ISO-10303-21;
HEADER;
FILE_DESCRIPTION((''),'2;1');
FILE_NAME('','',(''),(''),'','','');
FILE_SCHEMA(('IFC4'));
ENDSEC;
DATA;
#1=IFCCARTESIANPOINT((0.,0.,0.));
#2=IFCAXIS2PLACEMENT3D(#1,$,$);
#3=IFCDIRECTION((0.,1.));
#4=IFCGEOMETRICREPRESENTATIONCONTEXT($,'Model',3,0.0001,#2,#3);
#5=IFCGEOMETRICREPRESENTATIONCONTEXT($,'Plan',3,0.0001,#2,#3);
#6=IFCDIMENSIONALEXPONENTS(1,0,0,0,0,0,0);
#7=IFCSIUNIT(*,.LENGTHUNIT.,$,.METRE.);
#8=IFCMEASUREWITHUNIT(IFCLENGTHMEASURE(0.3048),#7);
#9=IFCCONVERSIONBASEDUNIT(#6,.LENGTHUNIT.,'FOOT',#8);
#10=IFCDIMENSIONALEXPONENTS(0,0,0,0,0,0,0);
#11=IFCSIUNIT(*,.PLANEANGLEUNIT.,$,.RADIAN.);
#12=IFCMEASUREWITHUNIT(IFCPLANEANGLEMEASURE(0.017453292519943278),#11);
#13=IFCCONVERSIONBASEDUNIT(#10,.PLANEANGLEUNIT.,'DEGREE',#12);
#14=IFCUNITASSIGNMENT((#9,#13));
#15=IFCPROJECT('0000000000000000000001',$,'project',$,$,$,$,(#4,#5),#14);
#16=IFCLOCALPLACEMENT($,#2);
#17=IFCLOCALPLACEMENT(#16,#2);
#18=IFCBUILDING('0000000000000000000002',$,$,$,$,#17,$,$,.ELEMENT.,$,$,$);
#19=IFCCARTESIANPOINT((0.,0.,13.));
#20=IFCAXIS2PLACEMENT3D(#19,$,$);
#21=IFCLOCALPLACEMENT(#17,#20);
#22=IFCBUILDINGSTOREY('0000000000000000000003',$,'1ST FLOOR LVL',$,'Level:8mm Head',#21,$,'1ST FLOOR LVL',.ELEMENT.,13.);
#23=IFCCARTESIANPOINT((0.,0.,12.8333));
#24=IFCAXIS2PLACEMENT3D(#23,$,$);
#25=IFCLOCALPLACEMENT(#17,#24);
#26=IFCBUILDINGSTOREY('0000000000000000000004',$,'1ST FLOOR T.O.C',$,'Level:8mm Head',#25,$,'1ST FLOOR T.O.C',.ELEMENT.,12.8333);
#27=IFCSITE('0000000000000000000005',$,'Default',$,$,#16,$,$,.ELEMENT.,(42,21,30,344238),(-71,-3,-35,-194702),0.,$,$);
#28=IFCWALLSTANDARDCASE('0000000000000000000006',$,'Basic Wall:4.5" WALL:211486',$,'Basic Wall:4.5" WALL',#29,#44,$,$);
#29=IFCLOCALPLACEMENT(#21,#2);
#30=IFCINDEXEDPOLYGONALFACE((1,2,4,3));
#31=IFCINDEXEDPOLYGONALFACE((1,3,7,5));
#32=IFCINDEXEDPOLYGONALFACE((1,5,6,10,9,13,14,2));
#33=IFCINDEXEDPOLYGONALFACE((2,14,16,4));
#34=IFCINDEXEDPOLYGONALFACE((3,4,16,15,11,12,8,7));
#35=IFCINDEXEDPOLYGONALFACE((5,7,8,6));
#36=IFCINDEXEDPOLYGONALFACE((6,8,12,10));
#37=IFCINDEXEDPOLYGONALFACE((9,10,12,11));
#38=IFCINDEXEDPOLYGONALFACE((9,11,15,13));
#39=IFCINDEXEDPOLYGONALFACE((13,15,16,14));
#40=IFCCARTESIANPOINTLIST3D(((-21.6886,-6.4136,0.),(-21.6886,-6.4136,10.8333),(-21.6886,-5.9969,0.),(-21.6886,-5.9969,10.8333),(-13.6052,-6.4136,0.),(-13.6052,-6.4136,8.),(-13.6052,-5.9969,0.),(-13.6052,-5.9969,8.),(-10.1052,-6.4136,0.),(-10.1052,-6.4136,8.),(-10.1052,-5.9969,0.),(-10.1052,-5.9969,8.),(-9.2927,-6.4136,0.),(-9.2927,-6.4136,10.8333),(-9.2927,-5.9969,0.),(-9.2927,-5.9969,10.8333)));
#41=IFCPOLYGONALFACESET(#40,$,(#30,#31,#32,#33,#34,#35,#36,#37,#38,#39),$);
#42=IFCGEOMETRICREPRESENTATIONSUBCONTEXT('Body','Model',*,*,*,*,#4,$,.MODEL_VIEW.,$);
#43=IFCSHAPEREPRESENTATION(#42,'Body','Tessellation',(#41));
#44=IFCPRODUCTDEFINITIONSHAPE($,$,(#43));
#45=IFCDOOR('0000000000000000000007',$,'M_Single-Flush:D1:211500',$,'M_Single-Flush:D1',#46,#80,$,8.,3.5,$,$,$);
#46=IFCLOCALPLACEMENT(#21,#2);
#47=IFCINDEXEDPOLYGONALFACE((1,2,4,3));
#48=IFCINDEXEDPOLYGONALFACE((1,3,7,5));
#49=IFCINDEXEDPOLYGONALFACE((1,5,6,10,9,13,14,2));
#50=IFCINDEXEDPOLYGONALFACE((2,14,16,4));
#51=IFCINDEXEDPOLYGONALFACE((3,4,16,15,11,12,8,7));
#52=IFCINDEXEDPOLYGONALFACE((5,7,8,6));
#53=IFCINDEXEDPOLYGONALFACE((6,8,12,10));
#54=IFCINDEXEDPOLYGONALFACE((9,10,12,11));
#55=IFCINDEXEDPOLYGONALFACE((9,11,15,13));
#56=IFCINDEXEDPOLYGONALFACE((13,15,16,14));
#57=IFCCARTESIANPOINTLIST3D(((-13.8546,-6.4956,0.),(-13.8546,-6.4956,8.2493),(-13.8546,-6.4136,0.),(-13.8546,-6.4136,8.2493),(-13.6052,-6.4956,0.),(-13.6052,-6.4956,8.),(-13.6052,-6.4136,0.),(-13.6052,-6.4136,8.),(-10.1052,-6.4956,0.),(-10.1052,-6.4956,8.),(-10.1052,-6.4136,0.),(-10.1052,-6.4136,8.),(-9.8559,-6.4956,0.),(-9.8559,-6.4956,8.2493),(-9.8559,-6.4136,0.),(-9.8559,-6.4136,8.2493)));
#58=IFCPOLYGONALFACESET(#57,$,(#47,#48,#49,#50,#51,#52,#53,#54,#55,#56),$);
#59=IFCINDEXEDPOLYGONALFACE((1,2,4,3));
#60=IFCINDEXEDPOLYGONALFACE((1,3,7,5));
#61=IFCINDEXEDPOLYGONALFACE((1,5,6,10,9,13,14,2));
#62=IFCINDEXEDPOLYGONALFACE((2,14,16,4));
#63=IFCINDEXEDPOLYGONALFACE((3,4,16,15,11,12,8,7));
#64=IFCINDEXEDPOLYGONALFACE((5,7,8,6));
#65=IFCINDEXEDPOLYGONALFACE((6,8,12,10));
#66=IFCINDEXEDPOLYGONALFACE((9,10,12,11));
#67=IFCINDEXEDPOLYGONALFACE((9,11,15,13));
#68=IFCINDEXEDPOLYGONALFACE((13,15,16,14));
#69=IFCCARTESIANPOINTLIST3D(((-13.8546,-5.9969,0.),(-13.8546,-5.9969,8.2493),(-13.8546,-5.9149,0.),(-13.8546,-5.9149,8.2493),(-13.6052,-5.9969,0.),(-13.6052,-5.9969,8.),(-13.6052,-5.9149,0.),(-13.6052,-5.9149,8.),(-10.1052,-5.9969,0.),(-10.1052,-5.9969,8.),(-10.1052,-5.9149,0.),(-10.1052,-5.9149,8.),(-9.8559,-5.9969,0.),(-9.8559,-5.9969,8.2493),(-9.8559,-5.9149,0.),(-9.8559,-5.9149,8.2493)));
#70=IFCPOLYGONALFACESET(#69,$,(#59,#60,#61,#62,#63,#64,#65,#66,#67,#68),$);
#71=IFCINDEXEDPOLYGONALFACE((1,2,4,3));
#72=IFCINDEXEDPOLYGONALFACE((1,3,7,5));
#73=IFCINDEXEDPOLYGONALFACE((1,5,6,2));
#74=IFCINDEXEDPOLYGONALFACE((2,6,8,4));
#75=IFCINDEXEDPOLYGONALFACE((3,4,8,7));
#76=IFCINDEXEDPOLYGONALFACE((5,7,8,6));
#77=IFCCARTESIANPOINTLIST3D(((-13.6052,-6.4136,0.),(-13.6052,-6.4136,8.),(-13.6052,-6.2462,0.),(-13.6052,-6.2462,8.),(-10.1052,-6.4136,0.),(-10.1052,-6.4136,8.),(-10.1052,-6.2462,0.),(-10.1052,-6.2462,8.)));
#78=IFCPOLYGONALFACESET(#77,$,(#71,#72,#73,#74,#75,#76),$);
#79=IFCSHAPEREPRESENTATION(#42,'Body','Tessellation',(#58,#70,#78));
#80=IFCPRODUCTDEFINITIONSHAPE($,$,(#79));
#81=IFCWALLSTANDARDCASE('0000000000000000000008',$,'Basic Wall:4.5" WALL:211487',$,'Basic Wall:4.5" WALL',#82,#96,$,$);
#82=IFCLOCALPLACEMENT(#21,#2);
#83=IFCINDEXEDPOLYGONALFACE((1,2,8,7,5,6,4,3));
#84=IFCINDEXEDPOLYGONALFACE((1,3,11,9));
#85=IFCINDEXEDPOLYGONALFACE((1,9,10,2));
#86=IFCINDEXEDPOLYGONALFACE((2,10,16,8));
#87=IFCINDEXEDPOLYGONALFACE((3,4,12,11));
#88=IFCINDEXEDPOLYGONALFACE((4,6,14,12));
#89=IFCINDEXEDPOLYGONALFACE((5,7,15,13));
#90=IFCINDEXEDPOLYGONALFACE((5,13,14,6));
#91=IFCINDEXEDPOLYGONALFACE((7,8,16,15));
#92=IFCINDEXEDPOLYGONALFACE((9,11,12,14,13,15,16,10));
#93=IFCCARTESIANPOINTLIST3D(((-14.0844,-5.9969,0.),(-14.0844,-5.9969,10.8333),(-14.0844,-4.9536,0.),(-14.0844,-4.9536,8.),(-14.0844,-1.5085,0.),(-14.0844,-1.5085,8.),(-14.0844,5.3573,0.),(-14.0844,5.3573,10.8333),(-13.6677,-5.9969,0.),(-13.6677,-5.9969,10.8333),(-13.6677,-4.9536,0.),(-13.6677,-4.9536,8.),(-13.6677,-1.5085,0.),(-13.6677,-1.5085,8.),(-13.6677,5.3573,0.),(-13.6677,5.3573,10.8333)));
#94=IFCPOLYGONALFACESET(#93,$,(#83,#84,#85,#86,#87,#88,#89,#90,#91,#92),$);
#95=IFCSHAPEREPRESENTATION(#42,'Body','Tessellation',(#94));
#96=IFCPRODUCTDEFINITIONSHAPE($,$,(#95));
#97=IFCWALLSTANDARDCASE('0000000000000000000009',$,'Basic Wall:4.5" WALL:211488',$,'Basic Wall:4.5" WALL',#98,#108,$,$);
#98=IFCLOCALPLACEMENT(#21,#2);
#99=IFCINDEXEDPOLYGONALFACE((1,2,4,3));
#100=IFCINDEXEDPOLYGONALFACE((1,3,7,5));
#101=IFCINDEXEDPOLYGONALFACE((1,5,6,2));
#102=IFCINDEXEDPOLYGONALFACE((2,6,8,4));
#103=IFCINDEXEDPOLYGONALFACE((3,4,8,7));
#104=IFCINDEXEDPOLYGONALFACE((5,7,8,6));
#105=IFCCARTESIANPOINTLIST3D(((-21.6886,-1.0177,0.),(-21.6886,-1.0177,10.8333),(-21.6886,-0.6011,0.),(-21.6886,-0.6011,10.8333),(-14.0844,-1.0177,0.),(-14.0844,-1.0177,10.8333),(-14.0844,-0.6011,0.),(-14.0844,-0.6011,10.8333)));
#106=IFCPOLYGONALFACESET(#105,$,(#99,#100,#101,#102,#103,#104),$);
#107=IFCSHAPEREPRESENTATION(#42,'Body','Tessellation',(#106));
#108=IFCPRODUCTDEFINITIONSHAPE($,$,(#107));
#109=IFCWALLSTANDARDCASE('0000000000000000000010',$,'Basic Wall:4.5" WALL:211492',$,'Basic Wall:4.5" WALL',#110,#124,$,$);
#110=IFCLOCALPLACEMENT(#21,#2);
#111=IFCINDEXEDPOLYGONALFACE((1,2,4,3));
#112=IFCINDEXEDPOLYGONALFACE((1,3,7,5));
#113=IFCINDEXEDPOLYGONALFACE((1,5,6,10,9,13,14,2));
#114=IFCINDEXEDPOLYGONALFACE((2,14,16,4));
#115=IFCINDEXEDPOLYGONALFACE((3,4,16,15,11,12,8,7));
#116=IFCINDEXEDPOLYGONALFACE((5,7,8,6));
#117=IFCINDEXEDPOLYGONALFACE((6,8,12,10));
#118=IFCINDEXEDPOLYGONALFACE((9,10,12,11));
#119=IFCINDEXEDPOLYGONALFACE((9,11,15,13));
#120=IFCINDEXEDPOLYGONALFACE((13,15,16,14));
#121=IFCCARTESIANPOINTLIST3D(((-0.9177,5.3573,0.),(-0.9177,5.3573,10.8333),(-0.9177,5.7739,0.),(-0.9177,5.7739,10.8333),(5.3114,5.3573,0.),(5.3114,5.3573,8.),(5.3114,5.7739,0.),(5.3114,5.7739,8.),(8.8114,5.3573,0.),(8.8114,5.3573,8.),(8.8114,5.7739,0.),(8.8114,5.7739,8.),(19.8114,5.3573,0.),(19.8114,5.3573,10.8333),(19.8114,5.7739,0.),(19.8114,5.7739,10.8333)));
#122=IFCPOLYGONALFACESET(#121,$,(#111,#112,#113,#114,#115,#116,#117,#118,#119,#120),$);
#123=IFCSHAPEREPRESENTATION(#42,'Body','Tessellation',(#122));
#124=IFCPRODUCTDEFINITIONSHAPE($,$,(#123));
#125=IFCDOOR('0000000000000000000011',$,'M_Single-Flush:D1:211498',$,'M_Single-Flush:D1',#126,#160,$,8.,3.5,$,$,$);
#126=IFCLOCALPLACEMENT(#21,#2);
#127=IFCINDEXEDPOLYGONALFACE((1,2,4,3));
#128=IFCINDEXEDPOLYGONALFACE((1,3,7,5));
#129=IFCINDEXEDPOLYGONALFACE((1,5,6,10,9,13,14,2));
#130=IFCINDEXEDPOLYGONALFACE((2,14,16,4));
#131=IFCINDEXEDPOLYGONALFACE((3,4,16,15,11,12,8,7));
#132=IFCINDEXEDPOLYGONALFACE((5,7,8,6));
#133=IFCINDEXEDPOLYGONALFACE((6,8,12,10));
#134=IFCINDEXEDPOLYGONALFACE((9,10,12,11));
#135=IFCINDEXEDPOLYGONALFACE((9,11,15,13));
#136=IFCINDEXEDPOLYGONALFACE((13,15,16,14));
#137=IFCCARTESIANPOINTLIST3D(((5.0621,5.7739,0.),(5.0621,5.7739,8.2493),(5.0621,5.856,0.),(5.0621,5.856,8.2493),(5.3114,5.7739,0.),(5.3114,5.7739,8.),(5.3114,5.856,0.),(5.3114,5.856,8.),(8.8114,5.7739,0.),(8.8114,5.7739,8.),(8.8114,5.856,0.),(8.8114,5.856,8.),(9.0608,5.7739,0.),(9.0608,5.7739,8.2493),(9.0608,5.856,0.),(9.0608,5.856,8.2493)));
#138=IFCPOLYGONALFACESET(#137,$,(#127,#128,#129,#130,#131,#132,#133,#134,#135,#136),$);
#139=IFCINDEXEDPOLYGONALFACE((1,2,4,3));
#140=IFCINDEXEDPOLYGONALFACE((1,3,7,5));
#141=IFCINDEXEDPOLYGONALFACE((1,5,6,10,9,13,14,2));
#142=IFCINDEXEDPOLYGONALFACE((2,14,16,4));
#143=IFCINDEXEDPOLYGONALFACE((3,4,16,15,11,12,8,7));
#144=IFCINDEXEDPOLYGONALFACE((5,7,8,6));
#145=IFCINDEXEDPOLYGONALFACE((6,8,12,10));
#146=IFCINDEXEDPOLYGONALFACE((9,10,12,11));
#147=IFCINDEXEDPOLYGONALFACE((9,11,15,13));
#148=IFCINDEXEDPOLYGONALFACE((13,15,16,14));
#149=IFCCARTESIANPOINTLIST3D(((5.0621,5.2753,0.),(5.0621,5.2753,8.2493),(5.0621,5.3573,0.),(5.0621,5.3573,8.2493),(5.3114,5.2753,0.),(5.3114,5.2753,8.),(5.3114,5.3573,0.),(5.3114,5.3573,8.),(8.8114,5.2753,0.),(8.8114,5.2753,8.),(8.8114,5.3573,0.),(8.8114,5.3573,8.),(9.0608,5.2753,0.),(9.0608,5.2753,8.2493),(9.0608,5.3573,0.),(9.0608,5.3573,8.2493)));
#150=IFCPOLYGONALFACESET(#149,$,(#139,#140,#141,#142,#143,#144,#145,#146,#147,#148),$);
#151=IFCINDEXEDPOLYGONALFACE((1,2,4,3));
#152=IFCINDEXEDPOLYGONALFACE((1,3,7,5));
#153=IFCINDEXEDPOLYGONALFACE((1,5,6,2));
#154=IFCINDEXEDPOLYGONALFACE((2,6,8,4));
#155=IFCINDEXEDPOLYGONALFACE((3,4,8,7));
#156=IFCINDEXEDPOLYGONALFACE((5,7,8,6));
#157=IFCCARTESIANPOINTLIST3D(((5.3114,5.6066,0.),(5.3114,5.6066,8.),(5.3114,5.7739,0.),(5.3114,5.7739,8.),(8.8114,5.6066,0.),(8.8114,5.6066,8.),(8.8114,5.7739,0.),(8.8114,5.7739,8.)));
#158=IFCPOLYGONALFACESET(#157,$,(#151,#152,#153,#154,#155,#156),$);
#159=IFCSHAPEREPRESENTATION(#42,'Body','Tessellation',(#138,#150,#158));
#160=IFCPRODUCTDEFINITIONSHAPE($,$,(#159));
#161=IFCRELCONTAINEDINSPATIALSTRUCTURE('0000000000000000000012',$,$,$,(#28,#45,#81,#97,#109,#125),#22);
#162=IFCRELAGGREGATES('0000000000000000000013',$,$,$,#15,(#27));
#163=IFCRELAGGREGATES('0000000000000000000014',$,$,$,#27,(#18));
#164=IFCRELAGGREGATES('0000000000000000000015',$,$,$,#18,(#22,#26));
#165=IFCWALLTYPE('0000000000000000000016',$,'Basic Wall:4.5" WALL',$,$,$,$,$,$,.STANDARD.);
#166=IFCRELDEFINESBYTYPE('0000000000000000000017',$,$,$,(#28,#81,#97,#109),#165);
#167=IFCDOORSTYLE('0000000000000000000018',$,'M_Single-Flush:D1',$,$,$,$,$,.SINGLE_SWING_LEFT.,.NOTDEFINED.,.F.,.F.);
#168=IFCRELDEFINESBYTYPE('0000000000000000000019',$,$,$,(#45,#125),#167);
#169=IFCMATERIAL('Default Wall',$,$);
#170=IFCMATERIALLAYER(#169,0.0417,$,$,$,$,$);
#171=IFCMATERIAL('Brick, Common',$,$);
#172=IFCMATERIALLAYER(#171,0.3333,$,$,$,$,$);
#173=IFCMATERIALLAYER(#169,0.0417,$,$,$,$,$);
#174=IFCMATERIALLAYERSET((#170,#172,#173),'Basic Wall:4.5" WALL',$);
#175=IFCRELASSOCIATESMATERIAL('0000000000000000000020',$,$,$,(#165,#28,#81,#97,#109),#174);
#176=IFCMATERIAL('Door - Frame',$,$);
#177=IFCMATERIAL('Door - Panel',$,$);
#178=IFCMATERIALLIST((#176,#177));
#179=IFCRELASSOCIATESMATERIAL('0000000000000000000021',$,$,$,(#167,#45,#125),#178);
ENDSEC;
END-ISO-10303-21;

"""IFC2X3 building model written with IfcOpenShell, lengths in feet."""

from ifc_helpers import new_model, entity, si_unit, converted_unit, direction, frame, frame_2d, origin, origin_2d_with_axis, place, context, subcontext, project, spatial, polyline, rectangle, outline, extrude, source, transform, mapped, material, material_list, layer, layer_set, layer_usage, type_object, type_shapes, element, fill, save


model = new_model("IFC2X3")

# Units and contexts
model_context = context("Model", 3, precision=0.0001, world=origin(), true_north=direction((0.0, 1.0)))
plan_context = context("Plan", 3, precision=0.0001, world=origin(), true_north=direction((0.0, 1.0)))
body_context = subcontext(model_context, "Body", "Model", "MODEL_VIEW")
ifc_project = project(units=[converted_unit("LENGTHUNIT", "FOOT", entity("IfcLengthMeasure", 0.3048), si_unit("LENGTHUNIT", "METRE"), dimensions=[1, 0, 0, 0, 0, 0, 0]), converted_unit("PLANEANGLEUNIT", "DEGREE", entity("IfcPlaneAngleMeasure", 0.017453292519943278), si_unit("PLANEANGLEUNIT", "RADIAN"), dimensions=[0, 0, 0, 0, 0, 0, 0])], contexts=[model_context, plan_context])

# Site, building, storey
site_placement = place(None, origin())
site = spatial("IfcSite", under=ifc_project, at=site_placement, Name="Default", CompositionType="ELEMENT", RefLatitude=(42, 21, 30, 344238), RefLongitude=(-71, -3, -35, -194702), RefElevation=0.0)
building_placement = place(site_placement, origin())
building = spatial("IfcBuilding", under=site, at=building_placement, CompositionType="ELEMENT")
storey_1_placement = place(building_placement, frame((0.0, 0.0, 13.0)))
storey_1 = spatial("IfcBuildingStorey", under=building, at=storey_1_placement, Name="1ST FLOOR LVL", ObjectType="Level:8mm Head", LongName="1ST FLOOR LVL", CompositionType="ELEMENT", Elevation=13.0)

# Shared definitions
ifc_material_1 = material(Name="Default Wall")
ifc_material_2 = material(Name="Brick, Common")

# Shared definitions
storey_2_placement = place(building_placement, frame((0.0, 0.0, 12.8333)))
storey_2 = spatial("IfcBuildingStorey", under=building, at=storey_2_placement, Name="1ST FLOOR T.O.C", ObjectType="Level:8mm Head", LongName="1ST FLOOR T.O.C", CompositionType="ELEMENT", Elevation=12.8333)

# Shared definitions
ifc_material_3 = material(Name="Door - Frame")
ifc_material_4 = material(Name="Door - Panel")
ifc_material_list_1 = material_list([ifc_material_3, ifc_material_4])

# Wall, opening, door
ifc_layer_1 = layer(ifc_material_1, 0.0417)
ifc_layer_2 = layer(ifc_material_2, 0.3333)
ifc_layer_3 = layer(ifc_material_1, 0.0417)
ifc_layer_set_1 = layer_set([ifc_layer_1, ifc_layer_2, ifc_layer_3], Name="Basic Wall:4.5\" WALL")
ifc_layer_usage_1 = layer_usage(ifc_layer_set_1, "AXIS2", "NEGATIVE", 0.2083)
wall_type_1 = type_object("IfcWallType", Name="Basic Wall:4.5\" WALL", PredefinedType="STANDARD", material=ifc_layer_set_1)
wall_1_placement = place(storey_1_placement, frame((-9.2927, -6.2052, 0.0), z_axis=(0.0, 0.0, 1.0), x_axis=(-1.0, 0.0, 0.0)))
wall_1 = element("IfcWallStandardCase", 1, at=wall_1_placement, inside=storey_1, type_object=wall_type_1, material=ifc_layer_usage_1, Name="Basic Wall:4.5\" WALL:211486", ObjectType="Basic Wall:4.5\" WALL", context=body_context, shape_type="SweptSolid", body=[
    extrude(rectangle(XDim=12.3958, YDim=0.4167, at=frame_2d((6.1979, 0.0), x_axis=(1.0, 0.0))), origin(), (0.0, 0.0, 1.0), 10.8333),
])
opening_1_placement = place(wall_1_placement, frame((0.8125, -0.2083, 0.0)))
opening_1 = element("IfcOpeningElement", 2, at=opening_1_placement, cuts=wall_1, ObjectType="Opening", context=body_context, shape_type="SweptSolid", body=[
    extrude(rectangle(XDim=3.5, YDim=8.0, at=frame_2d((4.0, 1.75), x_axis=(0.0, -1.0))), frame((0.0, 0.0, 0.0), z_axis=(0.0, 1.0, 0.0), x_axis=(0.0, 0.0, 1.0)), (0.0, 0.0, 1.0), 0.4167),
])
door_style_1 = type_object("IfcDoorStyle", Name="M_Single-Flush:D1", ConstructionType="NOTDEFINED", OperationType="SINGLE_SWING_LEFT", ParameterTakesPrecedence=False, Sizeable=False, material=ifc_material_list_1)
shared_shape_1 = source(origin(), body_context, "Body", "SweptSolid", [
    extrude(outline(polyline([(-1.9993, -4.187), (1.9993, -4.187), (1.9993, 4.0623), (1.75, 4.0623), (1.75, -3.9377), (-1.75, -3.9377), (-1.75, 4.0623), (-1.9993, 4.0623), (-1.9993, -4.187)])), frame((1.75, 0.4987, 4.0623), z_axis=(0.0, -1.0, 0.0), x_axis=(-1.0, 0.0, 0.0)), (0.0, 0.0, 1.0), 0.082),
    extrude(outline(polyline([(-4.187, -1.9993), (4.0623, -1.9993), (4.0623, -1.75), (-3.9377, -1.75), (-3.9377, 1.75), (4.0623, 1.75), (4.0623, 1.9993), (-4.187, 1.9993), (-4.187, -1.9993)])), frame((1.75, 0.0, 4.0623), z_axis=(0.0, -1.0, 0.0), x_axis=(0.0, 0.0, -1.0)), (0.0, 0.0, 1.0), 0.082),
    extrude(rectangle(XDim=3.5, YDim=0.1673, at=origin_2d_with_axis()), frame((1.75, 0.333, 0.0)), (0.0, 0.0, 1.0), 8.0),
])
type_shapes(door_style_1, [shared_shape_1])
door_1_placement = place(opening_1_placement, origin())
door_1 = element("IfcDoor", 3, at=door_1_placement, inside=storey_1, type_object=door_style_1, material=ifc_material_list_1, Name="M_Single-Flush:D1:211500", ObjectType="M_Single-Flush:D1", OverallHeight=8.0, OverallWidth=3.5, context=body_context, shape_type="MappedRepresentation", body=[
    mapped(shared_shape_1, transform((0.0, 0.0, 0.0), scale=1.0)),
])
fill(opening_1, door_1)

# Wall, opening
ifc_layer_usage_2 = layer_usage(ifc_layer_set_1, "AXIS2", "NEGATIVE", 0.2083)
wall_2_placement = place(storey_1_placement, frame((-13.8761, 5.3573, 0.0), z_axis=(0.0, 0.0, 1.0), x_axis=(0.0, -1.0, 0.0)))
wall_2 = element("IfcWallStandardCase", 4, at=wall_2_placement, inside=storey_1, type_object=wall_type_1, material=ifc_layer_usage_2, Name="Basic Wall:4.5\" WALL:211487", ObjectType="Basic Wall:4.5\" WALL", context=body_context, shape_type="SweptSolid", body=[
    extrude(rectangle(XDim=11.3542, YDim=0.4167, at=frame_2d((5.6771, 0.0), x_axis=(-1.0, 0.0))), origin(), (0.0, 0.0, 1.0), 10.8333),
])
opening_2_placement = place(wall_2_placement, origin())
element("IfcOpeningElement", 5, at=opening_2_placement, cuts=wall_2, ObjectType="Opening", context=body_context, shape_type="SweptSolid", body=[
    extrude(rectangle(XDim=8.0, YDim=3.4451, at=origin_2d_with_axis()), frame((8.5884, -0.2083, 4.0), z_axis=(0.0, 1.0, 0.0), x_axis=(0.0, 0.0, -1.0)), (0.0, 0.0, 1.0), 0.4167),
])

# Wall
ifc_layer_usage_3 = layer_usage(ifc_layer_set_1, "AXIS2", "NEGATIVE", 0.2083)
wall_3_placement = place(storey_1_placement, frame((-14.0844, -0.8094, 0.0), z_axis=(0.0, 0.0, 1.0), x_axis=(-1.0, 0.0, 0.0)))
element("IfcWallStandardCase", 6, at=wall_3_placement, inside=storey_1, type_object=wall_type_1, material=ifc_layer_usage_3, Name="Basic Wall:4.5\" WALL:211488", ObjectType="Basic Wall:4.5\" WALL", context=body_context, shape_type="SweptSolid", body=[
    extrude(rectangle(XDim=7.6042, YDim=0.4167, at=frame_2d((3.8021, 0.0), x_axis=(-1.0, 0.0))), origin(), (0.0, 0.0, 1.0), 10.8333),
])

# Wall, opening, door
ifc_layer_usage_4 = layer_usage(ifc_layer_set_1, "AXIS2", "NEGATIVE", 0.2083)
wall_4_placement = place(storey_1_placement, frame((-0.9177, 5.5656, 0.0)))
wall_4 = element("IfcWallStandardCase", 7, at=wall_4_placement, inside=storey_1, type_object=wall_type_1, material=ifc_layer_usage_4, Name="Basic Wall:4.5\" WALL:211492", ObjectType="Basic Wall:4.5\" WALL", context=body_context, shape_type="SweptSolid", body=[
    extrude(rectangle(XDim=20.7292, YDim=0.4167, at=frame_2d((10.3646, 0.0), x_axis=(1.0, 0.0))), origin(), (0.0, 0.0, 1.0), 10.8333),
])
opening_3_placement = place(wall_4_placement, frame((6.2292, -0.2083, 0.0)))
opening_3 = element("IfcOpeningElement", 8, at=opening_3_placement, cuts=wall_4, ObjectType="Opening", context=body_context, shape_type="SweptSolid", body=[
    extrude(rectangle(XDim=3.5, YDim=8.0, at=frame_2d((4.0, 1.75), x_axis=(0.0, -1.0))), frame((0.0, 0.0, 0.0), z_axis=(0.0, 1.0, 0.0), x_axis=(0.0, 0.0, 1.0)), (0.0, 0.0, 1.0), 0.4167),
])
door_2_placement = place(opening_3_placement, origin())
door_2 = element("IfcDoor", 9, at=door_2_placement, inside=storey_1, type_object=door_style_1, material=ifc_material_list_1, Name="M_Single-Flush:D1:211498", ObjectType="M_Single-Flush:D1", OverallHeight=8.0, OverallWidth=3.5, context=body_context, shape_type="MappedRepresentation", body=[
    mapped(shared_shape_1, transform((0.0, 0.0, 0.0), scale=1.0)),
])
fill(opening_3, door_2)

save(model, "model.ifc")
